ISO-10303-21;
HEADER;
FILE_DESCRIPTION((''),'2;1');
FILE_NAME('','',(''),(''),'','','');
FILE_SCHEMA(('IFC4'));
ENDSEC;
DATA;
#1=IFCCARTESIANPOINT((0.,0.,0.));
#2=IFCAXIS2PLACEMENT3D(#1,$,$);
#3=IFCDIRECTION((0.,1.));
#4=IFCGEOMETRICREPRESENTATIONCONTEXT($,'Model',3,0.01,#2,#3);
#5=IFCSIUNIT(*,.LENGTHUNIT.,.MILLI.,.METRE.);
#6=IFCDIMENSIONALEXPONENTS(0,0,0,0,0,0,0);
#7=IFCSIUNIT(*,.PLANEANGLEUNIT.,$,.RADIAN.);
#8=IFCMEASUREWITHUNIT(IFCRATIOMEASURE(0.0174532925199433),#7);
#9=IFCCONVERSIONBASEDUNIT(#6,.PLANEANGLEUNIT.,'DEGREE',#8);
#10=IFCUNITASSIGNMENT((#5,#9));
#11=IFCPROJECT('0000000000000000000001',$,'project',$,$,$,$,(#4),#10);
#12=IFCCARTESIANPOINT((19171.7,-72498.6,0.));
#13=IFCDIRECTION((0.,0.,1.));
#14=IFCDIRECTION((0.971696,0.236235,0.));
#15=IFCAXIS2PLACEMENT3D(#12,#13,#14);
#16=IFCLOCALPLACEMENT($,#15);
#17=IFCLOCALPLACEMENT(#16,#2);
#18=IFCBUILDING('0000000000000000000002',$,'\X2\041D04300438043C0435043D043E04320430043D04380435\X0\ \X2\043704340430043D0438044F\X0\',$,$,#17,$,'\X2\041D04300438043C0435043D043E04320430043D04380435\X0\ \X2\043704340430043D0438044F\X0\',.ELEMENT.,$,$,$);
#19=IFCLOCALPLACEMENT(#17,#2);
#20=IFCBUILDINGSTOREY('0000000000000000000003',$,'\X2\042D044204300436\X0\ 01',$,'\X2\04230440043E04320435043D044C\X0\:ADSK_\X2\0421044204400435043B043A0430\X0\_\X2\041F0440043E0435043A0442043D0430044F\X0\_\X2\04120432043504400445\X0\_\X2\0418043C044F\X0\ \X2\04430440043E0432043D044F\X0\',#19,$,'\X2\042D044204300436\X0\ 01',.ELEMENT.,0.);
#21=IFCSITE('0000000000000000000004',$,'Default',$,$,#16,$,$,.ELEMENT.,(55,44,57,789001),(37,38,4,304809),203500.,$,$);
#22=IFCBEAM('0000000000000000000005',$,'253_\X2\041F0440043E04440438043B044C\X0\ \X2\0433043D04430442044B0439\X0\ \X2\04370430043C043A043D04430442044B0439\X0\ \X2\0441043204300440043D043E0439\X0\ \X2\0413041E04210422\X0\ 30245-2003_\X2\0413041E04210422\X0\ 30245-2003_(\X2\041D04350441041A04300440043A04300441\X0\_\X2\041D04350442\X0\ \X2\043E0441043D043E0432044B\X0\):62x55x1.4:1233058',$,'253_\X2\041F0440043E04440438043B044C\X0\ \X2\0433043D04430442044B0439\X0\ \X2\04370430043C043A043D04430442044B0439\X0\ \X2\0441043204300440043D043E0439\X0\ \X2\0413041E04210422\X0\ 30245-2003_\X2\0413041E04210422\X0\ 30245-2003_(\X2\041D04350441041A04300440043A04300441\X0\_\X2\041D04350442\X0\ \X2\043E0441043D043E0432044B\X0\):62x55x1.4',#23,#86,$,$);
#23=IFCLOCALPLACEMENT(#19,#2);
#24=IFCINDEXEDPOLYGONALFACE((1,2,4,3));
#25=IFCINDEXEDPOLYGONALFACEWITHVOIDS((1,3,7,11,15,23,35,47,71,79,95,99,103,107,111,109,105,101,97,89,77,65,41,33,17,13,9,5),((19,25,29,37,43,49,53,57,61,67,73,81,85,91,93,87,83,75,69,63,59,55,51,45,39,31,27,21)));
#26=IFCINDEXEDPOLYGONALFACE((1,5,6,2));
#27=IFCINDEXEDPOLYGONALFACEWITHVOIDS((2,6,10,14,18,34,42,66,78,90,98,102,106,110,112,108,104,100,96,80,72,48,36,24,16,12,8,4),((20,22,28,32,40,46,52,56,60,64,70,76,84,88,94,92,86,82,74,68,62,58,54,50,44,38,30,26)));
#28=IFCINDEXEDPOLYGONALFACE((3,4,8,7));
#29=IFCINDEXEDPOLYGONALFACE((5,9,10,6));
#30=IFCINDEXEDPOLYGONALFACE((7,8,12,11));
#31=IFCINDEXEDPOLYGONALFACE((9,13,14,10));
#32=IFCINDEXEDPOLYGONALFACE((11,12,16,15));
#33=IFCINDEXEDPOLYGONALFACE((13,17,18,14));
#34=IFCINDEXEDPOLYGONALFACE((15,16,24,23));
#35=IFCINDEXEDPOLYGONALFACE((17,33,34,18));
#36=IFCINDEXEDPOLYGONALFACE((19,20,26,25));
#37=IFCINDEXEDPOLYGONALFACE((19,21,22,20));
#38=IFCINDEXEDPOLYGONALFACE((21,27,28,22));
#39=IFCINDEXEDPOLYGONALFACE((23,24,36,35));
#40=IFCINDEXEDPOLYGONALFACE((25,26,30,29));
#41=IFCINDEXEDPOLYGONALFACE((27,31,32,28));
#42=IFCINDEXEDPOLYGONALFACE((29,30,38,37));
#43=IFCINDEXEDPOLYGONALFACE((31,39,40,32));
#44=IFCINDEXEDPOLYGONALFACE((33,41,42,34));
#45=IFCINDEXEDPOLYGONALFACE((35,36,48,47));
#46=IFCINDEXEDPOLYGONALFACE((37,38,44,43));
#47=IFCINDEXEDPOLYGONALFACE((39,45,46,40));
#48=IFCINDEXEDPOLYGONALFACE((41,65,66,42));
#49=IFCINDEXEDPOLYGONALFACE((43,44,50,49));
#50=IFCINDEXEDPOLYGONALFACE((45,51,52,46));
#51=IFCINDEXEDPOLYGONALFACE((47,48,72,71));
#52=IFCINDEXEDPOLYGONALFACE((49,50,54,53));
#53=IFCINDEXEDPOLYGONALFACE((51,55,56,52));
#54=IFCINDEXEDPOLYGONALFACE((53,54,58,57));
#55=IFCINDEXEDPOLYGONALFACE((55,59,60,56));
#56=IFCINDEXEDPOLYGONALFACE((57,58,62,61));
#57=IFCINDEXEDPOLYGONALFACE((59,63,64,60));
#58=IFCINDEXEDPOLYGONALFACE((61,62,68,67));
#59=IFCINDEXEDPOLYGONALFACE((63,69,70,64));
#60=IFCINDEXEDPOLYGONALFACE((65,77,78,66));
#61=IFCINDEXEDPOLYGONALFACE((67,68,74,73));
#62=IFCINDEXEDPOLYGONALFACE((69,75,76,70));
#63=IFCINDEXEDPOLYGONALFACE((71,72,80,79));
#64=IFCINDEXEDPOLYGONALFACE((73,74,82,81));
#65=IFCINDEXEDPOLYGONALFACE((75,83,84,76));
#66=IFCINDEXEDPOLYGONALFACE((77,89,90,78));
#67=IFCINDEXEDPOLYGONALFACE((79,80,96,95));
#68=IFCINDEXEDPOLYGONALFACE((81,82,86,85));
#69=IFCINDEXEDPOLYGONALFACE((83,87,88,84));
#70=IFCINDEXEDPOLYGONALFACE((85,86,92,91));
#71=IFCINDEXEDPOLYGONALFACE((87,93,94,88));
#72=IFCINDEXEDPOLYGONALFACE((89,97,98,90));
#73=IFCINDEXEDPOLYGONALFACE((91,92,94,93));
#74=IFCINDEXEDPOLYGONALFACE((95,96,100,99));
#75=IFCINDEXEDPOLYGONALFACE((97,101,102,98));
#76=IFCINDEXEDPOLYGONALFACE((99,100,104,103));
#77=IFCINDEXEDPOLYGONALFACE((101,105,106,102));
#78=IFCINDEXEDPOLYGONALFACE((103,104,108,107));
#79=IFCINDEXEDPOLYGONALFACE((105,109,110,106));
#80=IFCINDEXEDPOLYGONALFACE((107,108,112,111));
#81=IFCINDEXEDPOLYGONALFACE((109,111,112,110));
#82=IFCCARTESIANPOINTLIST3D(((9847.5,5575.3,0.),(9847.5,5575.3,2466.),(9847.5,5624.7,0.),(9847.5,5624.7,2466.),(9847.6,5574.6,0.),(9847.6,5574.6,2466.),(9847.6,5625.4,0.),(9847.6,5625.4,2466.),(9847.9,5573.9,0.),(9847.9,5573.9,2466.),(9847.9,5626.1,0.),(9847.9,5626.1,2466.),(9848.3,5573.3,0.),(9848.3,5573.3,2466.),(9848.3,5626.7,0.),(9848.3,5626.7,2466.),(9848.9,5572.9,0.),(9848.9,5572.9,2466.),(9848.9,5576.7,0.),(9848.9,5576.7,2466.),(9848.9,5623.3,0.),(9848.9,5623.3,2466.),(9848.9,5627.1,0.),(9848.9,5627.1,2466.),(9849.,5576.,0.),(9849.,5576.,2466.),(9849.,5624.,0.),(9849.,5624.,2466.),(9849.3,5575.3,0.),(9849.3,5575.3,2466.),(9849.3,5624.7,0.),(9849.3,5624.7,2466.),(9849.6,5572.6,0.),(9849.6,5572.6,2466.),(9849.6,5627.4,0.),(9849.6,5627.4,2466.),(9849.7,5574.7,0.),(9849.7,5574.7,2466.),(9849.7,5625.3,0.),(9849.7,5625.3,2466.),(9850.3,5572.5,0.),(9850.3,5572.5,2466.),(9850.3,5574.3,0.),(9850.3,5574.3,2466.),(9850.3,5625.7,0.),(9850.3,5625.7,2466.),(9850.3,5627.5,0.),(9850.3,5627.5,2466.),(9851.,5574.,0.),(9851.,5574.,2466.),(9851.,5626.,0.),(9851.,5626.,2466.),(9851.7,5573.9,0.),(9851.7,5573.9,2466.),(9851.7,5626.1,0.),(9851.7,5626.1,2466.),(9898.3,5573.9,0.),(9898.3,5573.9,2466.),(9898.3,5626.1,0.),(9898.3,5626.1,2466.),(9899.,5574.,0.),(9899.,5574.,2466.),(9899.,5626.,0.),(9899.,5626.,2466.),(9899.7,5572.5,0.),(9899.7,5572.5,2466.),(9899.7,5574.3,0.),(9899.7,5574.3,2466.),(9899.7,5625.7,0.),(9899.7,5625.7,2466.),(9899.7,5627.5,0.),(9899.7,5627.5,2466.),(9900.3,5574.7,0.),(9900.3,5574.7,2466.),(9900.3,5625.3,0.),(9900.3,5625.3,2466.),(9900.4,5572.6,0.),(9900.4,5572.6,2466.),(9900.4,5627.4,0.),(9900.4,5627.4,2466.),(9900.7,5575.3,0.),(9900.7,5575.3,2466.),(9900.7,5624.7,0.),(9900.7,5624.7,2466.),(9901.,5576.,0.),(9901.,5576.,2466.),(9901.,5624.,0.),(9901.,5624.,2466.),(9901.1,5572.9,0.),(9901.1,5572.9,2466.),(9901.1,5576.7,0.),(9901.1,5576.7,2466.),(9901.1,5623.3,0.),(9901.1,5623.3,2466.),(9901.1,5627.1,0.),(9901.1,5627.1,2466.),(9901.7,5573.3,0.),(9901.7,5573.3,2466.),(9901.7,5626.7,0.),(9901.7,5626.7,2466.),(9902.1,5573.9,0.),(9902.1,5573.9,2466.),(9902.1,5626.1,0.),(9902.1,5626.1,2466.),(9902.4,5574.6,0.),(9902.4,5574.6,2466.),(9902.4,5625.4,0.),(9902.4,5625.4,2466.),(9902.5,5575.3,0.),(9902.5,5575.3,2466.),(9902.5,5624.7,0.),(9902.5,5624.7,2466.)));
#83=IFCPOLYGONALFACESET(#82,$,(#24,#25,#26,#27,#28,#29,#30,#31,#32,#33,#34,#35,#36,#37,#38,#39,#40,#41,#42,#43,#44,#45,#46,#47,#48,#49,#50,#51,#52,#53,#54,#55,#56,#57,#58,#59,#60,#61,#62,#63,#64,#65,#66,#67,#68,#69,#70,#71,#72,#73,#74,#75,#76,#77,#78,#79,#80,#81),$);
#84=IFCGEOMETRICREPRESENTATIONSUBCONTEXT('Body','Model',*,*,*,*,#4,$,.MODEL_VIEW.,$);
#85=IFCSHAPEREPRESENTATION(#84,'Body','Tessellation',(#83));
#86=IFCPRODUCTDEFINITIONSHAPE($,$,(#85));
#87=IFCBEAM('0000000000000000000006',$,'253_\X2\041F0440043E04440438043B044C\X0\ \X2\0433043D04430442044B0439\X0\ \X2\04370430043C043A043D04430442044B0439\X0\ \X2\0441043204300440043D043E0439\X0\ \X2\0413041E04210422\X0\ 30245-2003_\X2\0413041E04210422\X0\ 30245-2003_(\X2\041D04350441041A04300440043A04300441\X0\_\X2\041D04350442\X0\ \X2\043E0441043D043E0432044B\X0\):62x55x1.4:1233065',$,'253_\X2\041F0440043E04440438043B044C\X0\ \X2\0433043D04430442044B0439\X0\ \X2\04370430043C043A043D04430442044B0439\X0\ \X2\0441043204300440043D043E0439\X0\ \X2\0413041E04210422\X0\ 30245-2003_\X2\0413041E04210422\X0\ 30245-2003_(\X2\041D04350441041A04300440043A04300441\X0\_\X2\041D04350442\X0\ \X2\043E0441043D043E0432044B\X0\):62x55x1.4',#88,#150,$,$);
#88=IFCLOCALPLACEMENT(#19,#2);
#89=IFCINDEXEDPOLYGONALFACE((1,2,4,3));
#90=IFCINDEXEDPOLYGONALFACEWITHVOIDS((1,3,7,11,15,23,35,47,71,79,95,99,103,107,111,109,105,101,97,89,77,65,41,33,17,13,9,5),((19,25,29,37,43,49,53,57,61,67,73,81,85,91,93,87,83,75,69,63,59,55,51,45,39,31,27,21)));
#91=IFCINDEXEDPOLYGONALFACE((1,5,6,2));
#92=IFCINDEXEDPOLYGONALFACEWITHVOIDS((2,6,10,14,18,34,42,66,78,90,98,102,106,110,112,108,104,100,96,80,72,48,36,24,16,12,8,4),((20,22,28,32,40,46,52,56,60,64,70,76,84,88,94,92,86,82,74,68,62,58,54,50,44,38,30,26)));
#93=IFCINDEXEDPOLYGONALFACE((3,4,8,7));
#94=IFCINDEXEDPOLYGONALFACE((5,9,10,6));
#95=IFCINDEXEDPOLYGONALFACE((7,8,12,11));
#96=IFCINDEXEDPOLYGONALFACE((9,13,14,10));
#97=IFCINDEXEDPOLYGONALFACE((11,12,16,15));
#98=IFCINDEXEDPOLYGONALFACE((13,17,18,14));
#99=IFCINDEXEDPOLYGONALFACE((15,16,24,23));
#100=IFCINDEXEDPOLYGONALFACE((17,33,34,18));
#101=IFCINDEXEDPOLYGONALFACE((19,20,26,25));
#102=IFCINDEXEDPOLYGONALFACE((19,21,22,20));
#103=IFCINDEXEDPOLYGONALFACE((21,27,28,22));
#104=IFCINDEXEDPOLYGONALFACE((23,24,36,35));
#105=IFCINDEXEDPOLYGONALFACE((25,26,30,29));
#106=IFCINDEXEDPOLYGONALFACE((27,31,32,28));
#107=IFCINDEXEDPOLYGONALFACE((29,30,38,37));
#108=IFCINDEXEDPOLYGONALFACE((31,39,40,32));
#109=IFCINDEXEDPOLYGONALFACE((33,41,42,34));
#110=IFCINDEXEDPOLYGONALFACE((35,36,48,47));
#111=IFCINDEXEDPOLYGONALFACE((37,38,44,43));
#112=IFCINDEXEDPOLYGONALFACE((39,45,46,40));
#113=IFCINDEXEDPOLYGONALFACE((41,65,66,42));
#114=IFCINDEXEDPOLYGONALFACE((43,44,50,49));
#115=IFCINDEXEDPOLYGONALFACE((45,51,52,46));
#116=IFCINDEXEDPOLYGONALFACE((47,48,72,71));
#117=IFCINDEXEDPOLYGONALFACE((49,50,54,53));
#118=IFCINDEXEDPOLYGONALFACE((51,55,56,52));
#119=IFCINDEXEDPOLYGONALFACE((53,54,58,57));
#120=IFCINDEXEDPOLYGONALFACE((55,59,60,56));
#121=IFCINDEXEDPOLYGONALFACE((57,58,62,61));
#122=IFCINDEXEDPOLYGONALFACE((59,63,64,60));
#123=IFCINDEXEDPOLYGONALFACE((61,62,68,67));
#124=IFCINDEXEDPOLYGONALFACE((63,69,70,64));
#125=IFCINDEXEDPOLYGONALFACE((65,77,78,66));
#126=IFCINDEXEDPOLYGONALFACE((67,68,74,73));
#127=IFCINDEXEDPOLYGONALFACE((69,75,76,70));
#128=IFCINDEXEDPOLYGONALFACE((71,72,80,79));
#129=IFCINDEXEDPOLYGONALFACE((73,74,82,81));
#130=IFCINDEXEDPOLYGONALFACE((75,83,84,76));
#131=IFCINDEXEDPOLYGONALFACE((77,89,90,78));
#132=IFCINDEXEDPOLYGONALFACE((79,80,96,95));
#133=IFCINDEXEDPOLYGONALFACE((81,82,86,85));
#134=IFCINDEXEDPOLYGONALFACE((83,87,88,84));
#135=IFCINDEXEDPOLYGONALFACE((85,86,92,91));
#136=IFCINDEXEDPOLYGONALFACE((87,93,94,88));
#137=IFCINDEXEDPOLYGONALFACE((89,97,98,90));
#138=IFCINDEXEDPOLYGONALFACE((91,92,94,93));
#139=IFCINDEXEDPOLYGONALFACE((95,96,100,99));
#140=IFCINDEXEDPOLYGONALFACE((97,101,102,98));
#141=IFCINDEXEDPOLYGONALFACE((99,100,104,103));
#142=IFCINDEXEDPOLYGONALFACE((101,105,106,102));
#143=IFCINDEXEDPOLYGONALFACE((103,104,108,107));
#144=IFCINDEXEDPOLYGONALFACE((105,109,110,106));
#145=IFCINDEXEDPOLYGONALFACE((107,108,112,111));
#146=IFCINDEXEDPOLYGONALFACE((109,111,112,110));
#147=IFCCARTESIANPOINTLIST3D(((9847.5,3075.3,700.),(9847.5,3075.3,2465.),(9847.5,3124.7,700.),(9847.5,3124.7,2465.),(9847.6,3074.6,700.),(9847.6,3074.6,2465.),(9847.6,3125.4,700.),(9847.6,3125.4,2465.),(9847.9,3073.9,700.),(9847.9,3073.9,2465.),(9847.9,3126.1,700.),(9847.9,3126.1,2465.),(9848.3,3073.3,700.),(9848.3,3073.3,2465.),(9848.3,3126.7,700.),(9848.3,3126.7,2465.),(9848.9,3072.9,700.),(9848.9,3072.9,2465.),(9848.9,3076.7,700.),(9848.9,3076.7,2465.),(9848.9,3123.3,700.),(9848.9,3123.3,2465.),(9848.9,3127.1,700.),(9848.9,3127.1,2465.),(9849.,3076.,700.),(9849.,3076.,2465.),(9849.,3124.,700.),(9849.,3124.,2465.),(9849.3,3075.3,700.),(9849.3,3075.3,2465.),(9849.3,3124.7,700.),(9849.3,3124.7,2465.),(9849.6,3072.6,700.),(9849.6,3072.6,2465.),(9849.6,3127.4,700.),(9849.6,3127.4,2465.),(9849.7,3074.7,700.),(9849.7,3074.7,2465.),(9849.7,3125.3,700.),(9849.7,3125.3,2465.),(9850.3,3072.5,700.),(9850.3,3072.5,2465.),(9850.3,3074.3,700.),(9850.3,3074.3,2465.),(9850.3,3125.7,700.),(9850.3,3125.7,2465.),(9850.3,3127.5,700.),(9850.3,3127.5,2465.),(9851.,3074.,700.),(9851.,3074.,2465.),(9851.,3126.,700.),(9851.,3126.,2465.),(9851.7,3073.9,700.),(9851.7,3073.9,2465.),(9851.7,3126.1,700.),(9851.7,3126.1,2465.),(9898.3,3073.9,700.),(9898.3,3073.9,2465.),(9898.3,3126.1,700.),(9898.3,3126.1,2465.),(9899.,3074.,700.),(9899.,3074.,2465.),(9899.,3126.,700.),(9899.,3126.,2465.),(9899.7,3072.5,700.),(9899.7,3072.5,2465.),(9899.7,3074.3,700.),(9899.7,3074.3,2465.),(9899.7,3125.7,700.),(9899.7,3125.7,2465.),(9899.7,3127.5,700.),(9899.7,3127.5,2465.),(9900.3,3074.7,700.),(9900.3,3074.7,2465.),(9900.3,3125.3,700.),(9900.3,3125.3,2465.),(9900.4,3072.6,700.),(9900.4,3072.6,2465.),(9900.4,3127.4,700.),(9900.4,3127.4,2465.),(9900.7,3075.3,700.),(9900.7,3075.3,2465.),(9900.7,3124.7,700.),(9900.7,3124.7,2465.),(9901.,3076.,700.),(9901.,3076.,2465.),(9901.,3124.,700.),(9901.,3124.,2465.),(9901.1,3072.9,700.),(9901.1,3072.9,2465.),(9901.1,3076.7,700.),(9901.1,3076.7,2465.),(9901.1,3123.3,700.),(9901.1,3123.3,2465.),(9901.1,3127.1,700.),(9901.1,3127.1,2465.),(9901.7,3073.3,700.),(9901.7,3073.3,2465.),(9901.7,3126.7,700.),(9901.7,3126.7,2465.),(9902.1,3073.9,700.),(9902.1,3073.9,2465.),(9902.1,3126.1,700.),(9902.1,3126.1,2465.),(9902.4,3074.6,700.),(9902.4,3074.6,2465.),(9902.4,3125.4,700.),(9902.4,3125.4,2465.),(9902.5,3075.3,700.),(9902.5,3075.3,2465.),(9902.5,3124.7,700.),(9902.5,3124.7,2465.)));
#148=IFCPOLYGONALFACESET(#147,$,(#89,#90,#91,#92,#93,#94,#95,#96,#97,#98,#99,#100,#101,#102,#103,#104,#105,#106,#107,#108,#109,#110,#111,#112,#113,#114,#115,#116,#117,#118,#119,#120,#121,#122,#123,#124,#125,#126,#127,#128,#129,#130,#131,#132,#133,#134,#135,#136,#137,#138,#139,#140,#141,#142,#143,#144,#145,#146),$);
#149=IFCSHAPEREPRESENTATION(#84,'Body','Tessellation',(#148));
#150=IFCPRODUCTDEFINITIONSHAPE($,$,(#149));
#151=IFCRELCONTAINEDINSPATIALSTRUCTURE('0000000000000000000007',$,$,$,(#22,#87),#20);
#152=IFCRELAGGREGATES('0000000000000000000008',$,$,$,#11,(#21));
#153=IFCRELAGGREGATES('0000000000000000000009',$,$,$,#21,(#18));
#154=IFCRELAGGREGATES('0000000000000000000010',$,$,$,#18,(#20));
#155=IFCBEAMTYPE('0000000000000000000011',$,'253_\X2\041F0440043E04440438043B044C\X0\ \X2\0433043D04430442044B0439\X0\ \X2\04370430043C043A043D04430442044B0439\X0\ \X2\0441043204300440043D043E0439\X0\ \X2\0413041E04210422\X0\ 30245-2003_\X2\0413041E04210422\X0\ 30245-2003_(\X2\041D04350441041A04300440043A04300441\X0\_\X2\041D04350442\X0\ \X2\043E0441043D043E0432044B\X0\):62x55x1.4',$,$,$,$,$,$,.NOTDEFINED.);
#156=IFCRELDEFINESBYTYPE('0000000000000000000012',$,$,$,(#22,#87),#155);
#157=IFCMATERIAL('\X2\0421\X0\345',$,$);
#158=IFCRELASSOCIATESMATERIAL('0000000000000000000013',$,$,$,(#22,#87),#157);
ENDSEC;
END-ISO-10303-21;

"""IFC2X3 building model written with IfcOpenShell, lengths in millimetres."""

from ifc_helpers import new_model, entity, si_unit, converted_unit, direction, frame, frame_2d, origin, place, context, subcontext, project, spatial, polyline, circle_curve, parameter, trimmed, segment, composite_curve, outline, extrude, material, type_object, element, save


model = new_model("IFC2X3")

# Units and contexts
model_context = context("Model", 3, precision=0.01, world=origin(), true_north=direction((0.0, 1.0)))
body_context = subcontext(model_context, "Body", "Model", "MODEL_VIEW")
ifc_project = project(units=[si_unit("LENGTHUNIT", "METRE", prefix="MILLI"), converted_unit("PLANEANGLEUNIT", "DEGREE", entity("IfcRatioMeasure", 0.0174532925199433), si_unit("PLANEANGLEUNIT", "RADIAN"), dimensions=[0, 0, 0, 0, 0, 0, 0])], contexts=[model_context])

# Site, building, storey
site_placement = place(None, frame((19171.7, -72498.6, 0.0), z_axis=(0.0, 0.0, 1.0), x_axis=(0.971696, 0.236235, 0.0)))
site = spatial("IfcSite", under=ifc_project, at=site_placement, Name="Default", CompositionType="ELEMENT", RefLatitude=(55, 44, 57, 789001), RefLongitude=(37, 38, 4, 304809), RefElevation=203500.0)
building_placement = place(site_placement, origin())
building = spatial("IfcBuilding", under=site, at=building_placement, Name="Наименование здания", LongName="Наименование здания", CompositionType="ELEMENT")
storey_placement = place(building_placement, origin())
storey = spatial("IfcBuildingStorey", under=building, at=storey_placement, Name="Этаж 01", ObjectType="Уровень:ADSK_Стрелка_Проектная_Вверх_Имя уровня", LongName="Этаж 01", CompositionType="ELEMENT", Elevation=0.0)

# Beams
ifc_material_1 = material(Name="С345")
beam_type_1 = type_object("IfcBeamType", Name="253_Профиль гнутый замкнутый сварной ГОСТ 30245-2003_ГОСТ 30245-2003_(НесКаркас_Нет основы):62x55x1.4", PredefinedType="NOTDEFINED")
beam_1_placement = place(storey_placement, frame((9845.9, 5570.9, 0.0), z_axis=(1.0, 0.0, 0.0), x_axis=(0.0, 0.0, -1.0)))
element("IfcBeam", 1, at=beam_1_placement, inside=storey, type_object=beam_type_1, material=ifc_material_1, Name="253_Профиль гнутый замкнутый сварной ГОСТ 30245-2003_ГОСТ 30245-2003_(НесКаркас_Нет основы):62x55x1.4:1233058", ObjectType="253_Профиль гнутый замкнутый сварной ГОСТ 30245-2003_ГОСТ 30245-2003_(НесКаркас_Нет основы):62x55x1.4", context=body_context, shape_type="SweptSolid", body=[
    extrude(outline(composite_curve([segment(trimmed(circle_curve(frame_2d((24.7, -24.7), x_axis=(1.0, 0.0)), 2.8), [parameter(270.0)], [parameter(0.0)], True, "PARAMETER"), True, "CONTINUOUS"), segment(polyline([(27.5, -24.7), (27.5, 24.7)]), True, "CONTINUOUS"), segment(trimmed(circle_curve(frame_2d((24.7, 24.7), x_axis=(1.0, 0.0)), 2.8), [parameter(0.0)], [parameter(90.0)], True, "PARAMETER"), True, "CONTINUOUS"), segment(polyline([(24.7, 27.5), (-24.7, 27.5)]), True, "CONTINUOUS"), segment(trimmed(circle_curve(frame_2d((-24.7, 24.7), x_axis=(1.0, 0.0)), 2.8), [parameter(90.0)], [parameter(180.0)], True, "PARAMETER"), True, "CONTINUOUS"), segment(polyline([(-27.5, 24.7), (-27.5, -24.7)]), True, "CONTINUOUS"), segment(trimmed(circle_curve(frame_2d((-24.7, -24.7), x_axis=(1.0, 0.0)), 2.8), [parameter(180.0)], [parameter(270.0)], True, "PARAMETER"), True, "CONTINUOUS"), segment(polyline([(-24.7, -27.5), (24.7, -27.5)]), True, "CONTINUOUS")], self_intersect=False), holes=[composite_curve([segment(polyline([(23.3, -26.1), (-23.3, -26.1)]), True, "CONTINUOUS"), segment(trimmed(circle_curve(frame_2d((-23.3, -23.3), x_axis=(1.0, 0.0)), 2.8), [parameter(180.0)], [parameter(270.0)], True, "PARAMETER"), False, "CONTINUOUS"), segment(polyline([(-26.1, -23.3), (-26.1, 23.3)]), True, "CONTINUOUS"), segment(trimmed(circle_curve(frame_2d((-23.3, 23.3), x_axis=(1.0, 0.0)), 2.8), [parameter(90.0)], [parameter(180.0)], True, "PARAMETER"), False, "CONTINUOUS"), segment(polyline([(-23.3, 26.1), (23.3, 26.1)]), True, "CONTINUOUS"), segment(trimmed(circle_curve(frame_2d((23.3, 23.3), x_axis=(1.0, 0.0)), 2.8), [parameter(0.0)], [parameter(90.0)], True, "PARAMETER"), False, "CONTINUOUS"), segment(polyline([(26.1, 23.3), (26.1, -23.3)]), True, "CONTINUOUS"), segment(trimmed(circle_curve(frame_2d((23.3, -23.3), x_axis=(1.0, 0.0)), 2.8), [parameter(270.0)], [parameter(0.0)], True, "PARAMETER"), False, "CONTINUOUS")], self_intersect=False)]), frame((-2466.0, 29.1, 29.1), z_axis=(1.0, 0.0, 0.0), x_axis=(0.0, 1.0, 0.0)), (0.0, 0.0, 1.0), 2466.0),
])
beam_2_placement = place(storey_placement, frame((9845.9, 3070.9, 700.0), z_axis=(1.0, 0.0, 0.0), x_axis=(0.0, 0.0, 1.0)))
element("IfcBeam", 2, at=beam_2_placement, inside=storey, type_object=beam_type_1, material=ifc_material_1, Name="253_Профиль гнутый замкнутый сварной ГОСТ 30245-2003_ГОСТ 30245-2003_(НесКаркас_Нет основы):62x55x1.4:1233065", ObjectType="253_Профиль гнутый замкнутый сварной ГОСТ 30245-2003_ГОСТ 30245-2003_(НесКаркас_Нет основы):62x55x1.4", context=body_context, shape_type="SweptSolid", body=[
    extrude(outline(composite_curve([segment(trimmed(circle_curve(frame_2d((24.7, -24.7), x_axis=(1.0, 0.0)), 2.8), [parameter(270.0)], [parameter(0.0)], True, "PARAMETER"), True, "CONTINUOUS"), segment(polyline([(27.5, -24.7), (27.5, 24.7)]), True, "CONTINUOUS"), segment(trimmed(circle_curve(frame_2d((24.7, 24.7), x_axis=(1.0, 0.0)), 2.8), [parameter(0.0)], [parameter(90.0)], True, "PARAMETER"), True, "CONTINUOUS"), segment(polyline([(24.7, 27.5), (-24.7, 27.5)]), True, "CONTINUOUS"), segment(trimmed(circle_curve(frame_2d((-24.7, 24.7), x_axis=(1.0, 0.0)), 2.8), [parameter(90.0)], [parameter(180.0)], True, "PARAMETER"), True, "CONTINUOUS"), segment(polyline([(-27.5, 24.7), (-27.5, -24.7)]), True, "CONTINUOUS"), segment(trimmed(circle_curve(frame_2d((-24.7, -24.7), x_axis=(1.0, 0.0)), 2.8), [parameter(180.0)], [parameter(270.0)], True, "PARAMETER"), True, "CONTINUOUS"), segment(polyline([(-24.7, -27.5), (24.7, -27.5)]), True, "CONTINUOUS")], self_intersect=False), holes=[composite_curve([segment(polyline([(23.3, -26.1), (-23.3, -26.1)]), True, "CONTINUOUS"), segment(trimmed(circle_curve(frame_2d((-23.3, -23.3), x_axis=(1.0, 0.0)), 2.8), [parameter(180.0)], [parameter(270.0)], True, "PARAMETER"), False, "CONTINUOUS"), segment(polyline([(-26.1, -23.3), (-26.1, 23.3)]), True, "CONTINUOUS"), segment(trimmed(circle_curve(frame_2d((-23.3, 23.3), x_axis=(1.0, 0.0)), 2.8), [parameter(90.0)], [parameter(180.0)], True, "PARAMETER"), False, "CONTINUOUS"), segment(polyline([(-23.3, 26.1), (23.3, 26.1)]), True, "CONTINUOUS"), segment(trimmed(circle_curve(frame_2d((23.3, 23.3), x_axis=(1.0, 0.0)), 2.8), [parameter(0.0)], [parameter(90.0)], True, "PARAMETER"), False, "CONTINUOUS"), segment(polyline([(26.1, 23.3), (26.1, -23.3)]), True, "CONTINUOUS"), segment(trimmed(circle_curve(frame_2d((23.3, -23.3), x_axis=(1.0, 0.0)), 2.8), [parameter(270.0)], [parameter(0.0)], True, "PARAMETER"), False, "CONTINUOUS")], self_intersect=False)]), frame((0.0, -29.1, 29.1), z_axis=(1.0, 0.0, 0.0), x_axis=(0.0, -1.0, 0.0)), (0.0, 0.0, 1.0), 1765.0),
])

save(model, "model.ifc")
